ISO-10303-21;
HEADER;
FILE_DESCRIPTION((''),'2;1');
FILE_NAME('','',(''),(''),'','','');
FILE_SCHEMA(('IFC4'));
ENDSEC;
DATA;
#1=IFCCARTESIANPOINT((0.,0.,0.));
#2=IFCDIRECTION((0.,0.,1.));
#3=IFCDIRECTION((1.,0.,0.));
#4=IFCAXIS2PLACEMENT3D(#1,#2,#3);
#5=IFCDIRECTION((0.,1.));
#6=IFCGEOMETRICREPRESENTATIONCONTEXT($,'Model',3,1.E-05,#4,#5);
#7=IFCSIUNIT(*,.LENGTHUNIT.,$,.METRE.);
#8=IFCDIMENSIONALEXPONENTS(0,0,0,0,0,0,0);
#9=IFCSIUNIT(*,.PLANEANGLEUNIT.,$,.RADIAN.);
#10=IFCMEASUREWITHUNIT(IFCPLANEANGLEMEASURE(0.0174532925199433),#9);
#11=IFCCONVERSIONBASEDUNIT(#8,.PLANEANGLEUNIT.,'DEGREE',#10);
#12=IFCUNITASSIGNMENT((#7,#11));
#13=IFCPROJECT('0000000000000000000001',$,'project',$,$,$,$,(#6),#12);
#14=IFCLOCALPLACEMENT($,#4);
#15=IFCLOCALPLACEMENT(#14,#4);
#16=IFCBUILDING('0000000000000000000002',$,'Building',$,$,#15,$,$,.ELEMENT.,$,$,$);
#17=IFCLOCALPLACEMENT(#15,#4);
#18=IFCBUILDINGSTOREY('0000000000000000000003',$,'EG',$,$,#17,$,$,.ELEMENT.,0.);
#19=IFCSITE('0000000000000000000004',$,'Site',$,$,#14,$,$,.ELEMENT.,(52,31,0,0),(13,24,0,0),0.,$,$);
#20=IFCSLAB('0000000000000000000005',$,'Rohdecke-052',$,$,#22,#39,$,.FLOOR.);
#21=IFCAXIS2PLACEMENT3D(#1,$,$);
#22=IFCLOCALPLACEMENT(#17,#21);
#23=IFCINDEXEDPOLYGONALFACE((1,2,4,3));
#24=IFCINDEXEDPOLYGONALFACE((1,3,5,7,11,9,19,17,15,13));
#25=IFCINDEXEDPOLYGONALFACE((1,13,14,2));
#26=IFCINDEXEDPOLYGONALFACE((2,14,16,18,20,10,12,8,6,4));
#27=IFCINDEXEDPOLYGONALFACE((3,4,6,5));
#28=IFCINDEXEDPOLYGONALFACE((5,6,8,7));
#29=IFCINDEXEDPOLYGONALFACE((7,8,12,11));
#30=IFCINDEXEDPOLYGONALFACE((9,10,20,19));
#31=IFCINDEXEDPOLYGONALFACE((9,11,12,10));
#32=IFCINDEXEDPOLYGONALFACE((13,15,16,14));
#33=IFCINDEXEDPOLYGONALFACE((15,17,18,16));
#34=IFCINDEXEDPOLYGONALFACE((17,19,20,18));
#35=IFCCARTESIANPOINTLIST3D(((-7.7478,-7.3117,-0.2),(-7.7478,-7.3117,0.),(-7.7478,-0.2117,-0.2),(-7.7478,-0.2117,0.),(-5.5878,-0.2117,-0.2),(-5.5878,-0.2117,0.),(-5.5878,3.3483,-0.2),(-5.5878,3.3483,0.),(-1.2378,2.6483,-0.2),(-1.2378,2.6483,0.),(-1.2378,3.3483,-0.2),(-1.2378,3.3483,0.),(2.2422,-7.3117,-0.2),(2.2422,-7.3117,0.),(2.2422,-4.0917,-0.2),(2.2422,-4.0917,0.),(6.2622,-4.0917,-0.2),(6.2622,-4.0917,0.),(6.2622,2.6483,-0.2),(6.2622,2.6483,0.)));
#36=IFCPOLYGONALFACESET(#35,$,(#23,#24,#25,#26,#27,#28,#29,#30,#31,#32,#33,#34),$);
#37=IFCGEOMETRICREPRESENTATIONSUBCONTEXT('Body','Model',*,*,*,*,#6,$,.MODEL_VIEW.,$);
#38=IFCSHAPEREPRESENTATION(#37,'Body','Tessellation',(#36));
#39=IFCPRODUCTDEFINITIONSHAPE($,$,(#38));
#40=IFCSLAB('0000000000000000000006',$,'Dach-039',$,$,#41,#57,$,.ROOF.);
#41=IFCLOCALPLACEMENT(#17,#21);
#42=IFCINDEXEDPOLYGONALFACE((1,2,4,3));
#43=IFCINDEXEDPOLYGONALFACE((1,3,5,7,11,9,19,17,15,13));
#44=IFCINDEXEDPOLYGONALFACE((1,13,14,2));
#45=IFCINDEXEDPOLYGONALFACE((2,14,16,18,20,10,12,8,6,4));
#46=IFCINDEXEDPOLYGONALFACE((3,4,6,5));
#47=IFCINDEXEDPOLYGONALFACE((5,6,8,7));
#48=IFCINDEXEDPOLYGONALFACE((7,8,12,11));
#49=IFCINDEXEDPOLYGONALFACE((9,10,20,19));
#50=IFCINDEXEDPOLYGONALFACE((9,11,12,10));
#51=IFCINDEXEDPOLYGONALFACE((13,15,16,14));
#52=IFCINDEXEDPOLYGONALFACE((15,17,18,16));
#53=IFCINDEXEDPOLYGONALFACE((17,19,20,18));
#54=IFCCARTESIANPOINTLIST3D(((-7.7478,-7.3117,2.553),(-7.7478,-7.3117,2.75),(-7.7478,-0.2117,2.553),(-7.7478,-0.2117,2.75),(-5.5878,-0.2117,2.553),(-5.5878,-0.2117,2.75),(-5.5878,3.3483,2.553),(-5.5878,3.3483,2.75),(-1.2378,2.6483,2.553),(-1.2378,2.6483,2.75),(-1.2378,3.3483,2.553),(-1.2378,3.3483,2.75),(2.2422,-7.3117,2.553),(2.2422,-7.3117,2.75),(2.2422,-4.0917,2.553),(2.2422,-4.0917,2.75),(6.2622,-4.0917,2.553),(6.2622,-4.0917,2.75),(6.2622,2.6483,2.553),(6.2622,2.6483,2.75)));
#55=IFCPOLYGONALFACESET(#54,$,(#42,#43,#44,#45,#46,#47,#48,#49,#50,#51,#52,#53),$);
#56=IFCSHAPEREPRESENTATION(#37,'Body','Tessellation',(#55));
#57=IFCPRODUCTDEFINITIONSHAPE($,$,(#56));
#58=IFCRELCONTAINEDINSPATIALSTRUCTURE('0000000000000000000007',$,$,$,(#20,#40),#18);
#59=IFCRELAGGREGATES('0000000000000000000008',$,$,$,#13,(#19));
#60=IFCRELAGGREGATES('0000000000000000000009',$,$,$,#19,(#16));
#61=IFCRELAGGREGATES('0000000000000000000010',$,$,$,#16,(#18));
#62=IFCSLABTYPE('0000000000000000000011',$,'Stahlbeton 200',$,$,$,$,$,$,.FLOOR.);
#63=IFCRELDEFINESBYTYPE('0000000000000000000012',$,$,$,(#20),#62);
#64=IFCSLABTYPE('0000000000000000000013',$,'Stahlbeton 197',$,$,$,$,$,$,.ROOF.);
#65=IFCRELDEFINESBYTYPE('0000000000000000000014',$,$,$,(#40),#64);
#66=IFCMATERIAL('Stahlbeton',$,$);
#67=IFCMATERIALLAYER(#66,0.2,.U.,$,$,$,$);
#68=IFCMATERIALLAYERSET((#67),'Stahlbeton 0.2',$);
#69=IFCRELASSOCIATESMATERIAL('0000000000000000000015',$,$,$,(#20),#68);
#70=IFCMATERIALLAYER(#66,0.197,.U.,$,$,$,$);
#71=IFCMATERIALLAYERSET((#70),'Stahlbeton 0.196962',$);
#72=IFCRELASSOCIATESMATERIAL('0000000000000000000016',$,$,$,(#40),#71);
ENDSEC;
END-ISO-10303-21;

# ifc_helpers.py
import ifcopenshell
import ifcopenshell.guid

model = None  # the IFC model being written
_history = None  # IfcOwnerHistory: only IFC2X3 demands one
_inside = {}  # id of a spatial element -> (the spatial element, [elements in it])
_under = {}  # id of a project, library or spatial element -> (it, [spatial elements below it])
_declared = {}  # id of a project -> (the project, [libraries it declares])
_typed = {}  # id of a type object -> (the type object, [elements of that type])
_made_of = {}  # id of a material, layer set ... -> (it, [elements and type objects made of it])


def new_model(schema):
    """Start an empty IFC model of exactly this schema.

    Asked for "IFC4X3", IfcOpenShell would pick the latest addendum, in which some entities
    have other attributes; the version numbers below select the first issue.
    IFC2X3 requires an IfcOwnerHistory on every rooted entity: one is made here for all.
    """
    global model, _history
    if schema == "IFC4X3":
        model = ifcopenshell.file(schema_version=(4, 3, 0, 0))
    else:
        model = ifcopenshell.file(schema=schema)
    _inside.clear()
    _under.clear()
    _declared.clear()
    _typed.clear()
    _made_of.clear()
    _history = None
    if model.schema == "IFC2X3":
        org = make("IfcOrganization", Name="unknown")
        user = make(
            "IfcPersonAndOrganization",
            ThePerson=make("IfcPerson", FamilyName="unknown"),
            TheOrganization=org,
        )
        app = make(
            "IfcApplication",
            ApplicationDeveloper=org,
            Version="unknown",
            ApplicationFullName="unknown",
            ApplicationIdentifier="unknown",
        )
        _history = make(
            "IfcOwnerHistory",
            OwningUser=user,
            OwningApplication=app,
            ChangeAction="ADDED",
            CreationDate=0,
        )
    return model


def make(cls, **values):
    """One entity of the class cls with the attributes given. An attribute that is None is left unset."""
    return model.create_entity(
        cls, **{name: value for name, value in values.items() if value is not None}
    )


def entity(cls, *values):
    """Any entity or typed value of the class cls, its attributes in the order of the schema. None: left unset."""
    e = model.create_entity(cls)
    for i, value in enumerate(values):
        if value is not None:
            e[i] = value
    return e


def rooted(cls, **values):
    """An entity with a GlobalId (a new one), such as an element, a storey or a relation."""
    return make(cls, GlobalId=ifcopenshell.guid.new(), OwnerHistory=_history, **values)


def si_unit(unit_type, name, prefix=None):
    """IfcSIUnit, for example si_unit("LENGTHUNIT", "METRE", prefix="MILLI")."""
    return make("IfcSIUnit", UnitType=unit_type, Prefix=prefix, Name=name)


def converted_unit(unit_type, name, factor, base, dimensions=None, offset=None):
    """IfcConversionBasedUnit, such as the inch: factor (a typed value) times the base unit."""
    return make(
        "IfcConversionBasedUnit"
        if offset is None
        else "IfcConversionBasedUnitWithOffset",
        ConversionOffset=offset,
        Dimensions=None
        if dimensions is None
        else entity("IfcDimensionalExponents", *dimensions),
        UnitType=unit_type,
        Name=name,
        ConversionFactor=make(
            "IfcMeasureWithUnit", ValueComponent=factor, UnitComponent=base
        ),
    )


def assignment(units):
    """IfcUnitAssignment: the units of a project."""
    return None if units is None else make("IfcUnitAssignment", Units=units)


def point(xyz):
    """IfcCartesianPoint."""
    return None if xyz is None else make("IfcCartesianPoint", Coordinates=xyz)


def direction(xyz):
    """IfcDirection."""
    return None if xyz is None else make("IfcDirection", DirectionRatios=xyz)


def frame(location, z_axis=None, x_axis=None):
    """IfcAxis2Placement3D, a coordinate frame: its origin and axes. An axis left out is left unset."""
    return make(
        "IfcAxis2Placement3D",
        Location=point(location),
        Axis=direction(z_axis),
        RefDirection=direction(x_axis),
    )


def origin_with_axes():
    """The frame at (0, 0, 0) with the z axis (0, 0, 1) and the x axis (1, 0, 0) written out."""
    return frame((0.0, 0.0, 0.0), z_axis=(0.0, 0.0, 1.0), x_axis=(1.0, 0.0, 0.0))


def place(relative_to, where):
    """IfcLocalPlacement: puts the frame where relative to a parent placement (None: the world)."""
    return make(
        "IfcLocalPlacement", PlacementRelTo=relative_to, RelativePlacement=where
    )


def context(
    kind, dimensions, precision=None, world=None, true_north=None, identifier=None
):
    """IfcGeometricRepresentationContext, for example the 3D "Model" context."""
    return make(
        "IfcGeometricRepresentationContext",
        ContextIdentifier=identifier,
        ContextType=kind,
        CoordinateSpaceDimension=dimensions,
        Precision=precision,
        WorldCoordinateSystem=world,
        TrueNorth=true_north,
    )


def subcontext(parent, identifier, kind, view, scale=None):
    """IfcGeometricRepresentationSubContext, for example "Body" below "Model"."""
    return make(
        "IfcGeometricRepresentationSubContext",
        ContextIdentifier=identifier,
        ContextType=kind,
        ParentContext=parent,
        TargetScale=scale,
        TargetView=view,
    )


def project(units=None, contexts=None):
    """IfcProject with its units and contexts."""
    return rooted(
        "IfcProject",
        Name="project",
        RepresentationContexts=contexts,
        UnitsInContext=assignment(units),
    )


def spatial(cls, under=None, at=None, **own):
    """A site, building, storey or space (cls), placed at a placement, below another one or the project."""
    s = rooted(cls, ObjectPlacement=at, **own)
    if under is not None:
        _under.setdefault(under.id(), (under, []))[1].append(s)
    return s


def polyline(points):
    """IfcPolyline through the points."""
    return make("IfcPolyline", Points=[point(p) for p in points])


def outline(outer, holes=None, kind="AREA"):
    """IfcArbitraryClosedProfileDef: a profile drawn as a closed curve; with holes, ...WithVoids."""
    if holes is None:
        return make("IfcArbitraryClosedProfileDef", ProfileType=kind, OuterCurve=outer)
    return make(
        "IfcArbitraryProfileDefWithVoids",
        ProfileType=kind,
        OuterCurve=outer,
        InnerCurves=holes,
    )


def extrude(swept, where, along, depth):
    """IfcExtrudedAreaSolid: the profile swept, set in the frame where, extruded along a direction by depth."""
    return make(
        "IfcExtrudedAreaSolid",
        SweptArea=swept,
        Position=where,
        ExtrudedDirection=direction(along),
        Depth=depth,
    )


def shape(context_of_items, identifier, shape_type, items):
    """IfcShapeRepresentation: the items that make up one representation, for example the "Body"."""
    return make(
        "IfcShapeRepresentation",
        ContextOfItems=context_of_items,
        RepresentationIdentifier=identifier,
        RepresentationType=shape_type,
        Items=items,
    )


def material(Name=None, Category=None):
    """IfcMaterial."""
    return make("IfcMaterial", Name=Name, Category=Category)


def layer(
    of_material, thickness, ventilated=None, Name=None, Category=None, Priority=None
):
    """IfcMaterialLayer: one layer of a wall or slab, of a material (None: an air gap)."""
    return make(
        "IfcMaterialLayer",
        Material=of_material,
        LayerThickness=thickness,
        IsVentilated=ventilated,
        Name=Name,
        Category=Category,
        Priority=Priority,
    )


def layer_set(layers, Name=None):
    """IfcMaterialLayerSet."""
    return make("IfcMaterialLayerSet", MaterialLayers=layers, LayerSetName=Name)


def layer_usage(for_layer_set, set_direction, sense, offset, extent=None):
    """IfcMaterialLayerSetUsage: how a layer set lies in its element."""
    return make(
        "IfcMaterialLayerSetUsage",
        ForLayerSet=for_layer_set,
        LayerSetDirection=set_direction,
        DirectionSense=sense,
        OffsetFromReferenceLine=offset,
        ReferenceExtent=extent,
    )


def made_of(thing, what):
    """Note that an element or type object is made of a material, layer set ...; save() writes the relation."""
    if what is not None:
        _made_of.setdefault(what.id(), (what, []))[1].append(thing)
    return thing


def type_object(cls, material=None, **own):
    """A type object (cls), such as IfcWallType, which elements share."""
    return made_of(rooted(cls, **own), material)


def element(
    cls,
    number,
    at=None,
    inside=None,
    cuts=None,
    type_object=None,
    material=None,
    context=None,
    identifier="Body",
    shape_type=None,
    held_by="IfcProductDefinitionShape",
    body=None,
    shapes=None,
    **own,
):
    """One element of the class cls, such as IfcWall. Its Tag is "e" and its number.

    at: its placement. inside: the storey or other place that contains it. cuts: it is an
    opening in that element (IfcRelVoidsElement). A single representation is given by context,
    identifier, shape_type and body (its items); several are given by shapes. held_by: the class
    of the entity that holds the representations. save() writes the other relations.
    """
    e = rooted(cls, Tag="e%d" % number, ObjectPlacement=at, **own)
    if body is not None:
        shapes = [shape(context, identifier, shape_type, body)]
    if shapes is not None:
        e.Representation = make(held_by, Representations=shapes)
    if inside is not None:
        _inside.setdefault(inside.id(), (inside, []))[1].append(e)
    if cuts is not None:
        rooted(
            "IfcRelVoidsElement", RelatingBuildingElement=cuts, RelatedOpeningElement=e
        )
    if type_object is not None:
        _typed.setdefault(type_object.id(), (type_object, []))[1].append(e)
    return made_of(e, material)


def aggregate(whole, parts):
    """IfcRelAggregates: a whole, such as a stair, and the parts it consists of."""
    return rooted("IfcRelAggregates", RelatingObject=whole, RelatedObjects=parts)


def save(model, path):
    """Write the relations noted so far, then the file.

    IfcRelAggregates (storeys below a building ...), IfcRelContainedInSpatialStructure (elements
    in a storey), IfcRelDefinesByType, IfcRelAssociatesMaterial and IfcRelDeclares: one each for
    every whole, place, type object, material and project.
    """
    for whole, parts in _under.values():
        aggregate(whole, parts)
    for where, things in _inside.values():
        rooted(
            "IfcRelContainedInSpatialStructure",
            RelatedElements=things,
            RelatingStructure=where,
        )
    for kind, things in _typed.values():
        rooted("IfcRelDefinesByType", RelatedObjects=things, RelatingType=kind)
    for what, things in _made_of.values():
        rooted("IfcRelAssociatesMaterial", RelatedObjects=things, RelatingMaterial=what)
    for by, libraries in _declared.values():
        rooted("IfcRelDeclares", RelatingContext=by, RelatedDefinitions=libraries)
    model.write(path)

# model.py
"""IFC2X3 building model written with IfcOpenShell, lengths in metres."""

from ifc_helpers import new_model, entity, si_unit, converted_unit, direction, frame, origin_with_axes, place, context, subcontext, project, spatial, polyline, outline, extrude, material, layer, layer_set, layer_usage, type_object, element, save


model = new_model("IFC2X3")

# Units and contexts
model_context = context("Model", 3, precision=1e-05, world=origin_with_axes(), true_north=direction((0.0, 1.0)))
body_context = subcontext(model_context, "Body", "Model", "MODEL_VIEW")
ifc_project = project(units=[si_unit("LENGTHUNIT", "METRE"), converted_unit("PLANEANGLEUNIT", "DEGREE", entity("IfcPlaneAngleMeasure", 0.0174532925199433), si_unit("PLANEANGLEUNIT", "RADIAN"), dimensions=[0, 0, 0, 0, 0, 0, 0])], contexts=[model_context])

# Site, building, storey
site_placement = place(None, origin_with_axes())
site = spatial("IfcSite", under=ifc_project, at=site_placement, Name="Site", CompositionType="ELEMENT", RefLatitude=(52, 31, 0, 0), RefLongitude=(13, 24, 0, 0), RefElevation=0.0)
building_placement = place(site_placement, origin_with_axes())
building = spatial("IfcBuilding", under=site, at=building_placement, Name="Building", CompositionType="ELEMENT")
storey_placement = place(building_placement, origin_with_axes())
storey = spatial("IfcBuildingStorey", under=building, at=storey_placement, Name="EG", CompositionType="ELEMENT", Elevation=0.0)

# Slabs
ifc_material = material(Name="Stahlbeton")
ifc_layer_1 = layer(ifc_material, 0.2, ventilated="UNKNOWN")
ifc_layer_set_1 = layer_set([ifc_layer_1], Name="Stahlbeton 0.2")
ifc_layer_usage_1 = layer_usage(ifc_layer_set_1, "AXIS3", "NEGATIVE", 0.2)
slab_type_1 = type_object("IfcSlabType", Name="Stahlbeton 200", PredefinedType="FLOOR")
slab_1_placement = place(storey_placement, frame((-7.7478, -7.3117, 0.0), z_axis=(0.0, 0.0, 1.0), x_axis=(1.0, 0.0, 0.0)))
element("IfcSlab", 1, at=slab_1_placement, inside=storey, type_object=slab_type_1, material=ifc_layer_usage_1, Name="Rohdecke-052", PredefinedType="FLOOR", context=body_context, shape_type="SweptSolid", body=[
    extrude(outline(polyline([(0.0, 0.0), (9.99, 0.0), (9.99, 3.22), (14.01, 3.22), (14.01, 9.96), (6.51, 9.96), (6.51, 10.66), (2.16, 10.66), (2.16, 7.1), (0.0, 7.1), (0.0, 0.0)])), frame((0.0, 0.0, -0.2), z_axis=(0.0, 0.0, 1.0), x_axis=(1.0, 0.0, 0.0)), (0.0, 0.0, 1.0), 0.2),
])
ifc_layer_2 = layer(ifc_material, 0.197, ventilated="UNKNOWN")
ifc_layer_set_2 = layer_set([ifc_layer_2], Name="Stahlbeton 0.196962")
ifc_layer_usage_2 = layer_usage(ifc_layer_set_2, "AXIS3", "NEGATIVE", 0.197)
slab_type_2 = type_object("IfcSlabType", Name="Stahlbeton 197", PredefinedType="ROOF")
slab_2_placement = place(storey_placement, frame((-7.7478, -7.3117, 2.553), z_axis=(0.0, 0.0, 1.0), x_axis=(1.0, 0.0, 0.0)))
element("IfcSlab", 2, at=slab_2_placement, inside=storey, type_object=slab_type_2, material=ifc_layer_usage_2, Name="Dach-039", PredefinedType="ROOF", context=body_context, shape_type="SweptSolid", body=[
    extrude(outline(polyline([(9.99, 0.0), (9.99, 3.22), (14.01, 3.22), (14.01, 9.96), (6.51, 9.96), (6.51, 10.66), (2.16, 10.66), (2.16, 7.1), (0.0, 7.1), (0.0, 0.0), (9.99, 0.0)])), origin_with_axes(), (0.0, 0.0, 1.0), 0.197),
])

save(model, "model.ifc")
